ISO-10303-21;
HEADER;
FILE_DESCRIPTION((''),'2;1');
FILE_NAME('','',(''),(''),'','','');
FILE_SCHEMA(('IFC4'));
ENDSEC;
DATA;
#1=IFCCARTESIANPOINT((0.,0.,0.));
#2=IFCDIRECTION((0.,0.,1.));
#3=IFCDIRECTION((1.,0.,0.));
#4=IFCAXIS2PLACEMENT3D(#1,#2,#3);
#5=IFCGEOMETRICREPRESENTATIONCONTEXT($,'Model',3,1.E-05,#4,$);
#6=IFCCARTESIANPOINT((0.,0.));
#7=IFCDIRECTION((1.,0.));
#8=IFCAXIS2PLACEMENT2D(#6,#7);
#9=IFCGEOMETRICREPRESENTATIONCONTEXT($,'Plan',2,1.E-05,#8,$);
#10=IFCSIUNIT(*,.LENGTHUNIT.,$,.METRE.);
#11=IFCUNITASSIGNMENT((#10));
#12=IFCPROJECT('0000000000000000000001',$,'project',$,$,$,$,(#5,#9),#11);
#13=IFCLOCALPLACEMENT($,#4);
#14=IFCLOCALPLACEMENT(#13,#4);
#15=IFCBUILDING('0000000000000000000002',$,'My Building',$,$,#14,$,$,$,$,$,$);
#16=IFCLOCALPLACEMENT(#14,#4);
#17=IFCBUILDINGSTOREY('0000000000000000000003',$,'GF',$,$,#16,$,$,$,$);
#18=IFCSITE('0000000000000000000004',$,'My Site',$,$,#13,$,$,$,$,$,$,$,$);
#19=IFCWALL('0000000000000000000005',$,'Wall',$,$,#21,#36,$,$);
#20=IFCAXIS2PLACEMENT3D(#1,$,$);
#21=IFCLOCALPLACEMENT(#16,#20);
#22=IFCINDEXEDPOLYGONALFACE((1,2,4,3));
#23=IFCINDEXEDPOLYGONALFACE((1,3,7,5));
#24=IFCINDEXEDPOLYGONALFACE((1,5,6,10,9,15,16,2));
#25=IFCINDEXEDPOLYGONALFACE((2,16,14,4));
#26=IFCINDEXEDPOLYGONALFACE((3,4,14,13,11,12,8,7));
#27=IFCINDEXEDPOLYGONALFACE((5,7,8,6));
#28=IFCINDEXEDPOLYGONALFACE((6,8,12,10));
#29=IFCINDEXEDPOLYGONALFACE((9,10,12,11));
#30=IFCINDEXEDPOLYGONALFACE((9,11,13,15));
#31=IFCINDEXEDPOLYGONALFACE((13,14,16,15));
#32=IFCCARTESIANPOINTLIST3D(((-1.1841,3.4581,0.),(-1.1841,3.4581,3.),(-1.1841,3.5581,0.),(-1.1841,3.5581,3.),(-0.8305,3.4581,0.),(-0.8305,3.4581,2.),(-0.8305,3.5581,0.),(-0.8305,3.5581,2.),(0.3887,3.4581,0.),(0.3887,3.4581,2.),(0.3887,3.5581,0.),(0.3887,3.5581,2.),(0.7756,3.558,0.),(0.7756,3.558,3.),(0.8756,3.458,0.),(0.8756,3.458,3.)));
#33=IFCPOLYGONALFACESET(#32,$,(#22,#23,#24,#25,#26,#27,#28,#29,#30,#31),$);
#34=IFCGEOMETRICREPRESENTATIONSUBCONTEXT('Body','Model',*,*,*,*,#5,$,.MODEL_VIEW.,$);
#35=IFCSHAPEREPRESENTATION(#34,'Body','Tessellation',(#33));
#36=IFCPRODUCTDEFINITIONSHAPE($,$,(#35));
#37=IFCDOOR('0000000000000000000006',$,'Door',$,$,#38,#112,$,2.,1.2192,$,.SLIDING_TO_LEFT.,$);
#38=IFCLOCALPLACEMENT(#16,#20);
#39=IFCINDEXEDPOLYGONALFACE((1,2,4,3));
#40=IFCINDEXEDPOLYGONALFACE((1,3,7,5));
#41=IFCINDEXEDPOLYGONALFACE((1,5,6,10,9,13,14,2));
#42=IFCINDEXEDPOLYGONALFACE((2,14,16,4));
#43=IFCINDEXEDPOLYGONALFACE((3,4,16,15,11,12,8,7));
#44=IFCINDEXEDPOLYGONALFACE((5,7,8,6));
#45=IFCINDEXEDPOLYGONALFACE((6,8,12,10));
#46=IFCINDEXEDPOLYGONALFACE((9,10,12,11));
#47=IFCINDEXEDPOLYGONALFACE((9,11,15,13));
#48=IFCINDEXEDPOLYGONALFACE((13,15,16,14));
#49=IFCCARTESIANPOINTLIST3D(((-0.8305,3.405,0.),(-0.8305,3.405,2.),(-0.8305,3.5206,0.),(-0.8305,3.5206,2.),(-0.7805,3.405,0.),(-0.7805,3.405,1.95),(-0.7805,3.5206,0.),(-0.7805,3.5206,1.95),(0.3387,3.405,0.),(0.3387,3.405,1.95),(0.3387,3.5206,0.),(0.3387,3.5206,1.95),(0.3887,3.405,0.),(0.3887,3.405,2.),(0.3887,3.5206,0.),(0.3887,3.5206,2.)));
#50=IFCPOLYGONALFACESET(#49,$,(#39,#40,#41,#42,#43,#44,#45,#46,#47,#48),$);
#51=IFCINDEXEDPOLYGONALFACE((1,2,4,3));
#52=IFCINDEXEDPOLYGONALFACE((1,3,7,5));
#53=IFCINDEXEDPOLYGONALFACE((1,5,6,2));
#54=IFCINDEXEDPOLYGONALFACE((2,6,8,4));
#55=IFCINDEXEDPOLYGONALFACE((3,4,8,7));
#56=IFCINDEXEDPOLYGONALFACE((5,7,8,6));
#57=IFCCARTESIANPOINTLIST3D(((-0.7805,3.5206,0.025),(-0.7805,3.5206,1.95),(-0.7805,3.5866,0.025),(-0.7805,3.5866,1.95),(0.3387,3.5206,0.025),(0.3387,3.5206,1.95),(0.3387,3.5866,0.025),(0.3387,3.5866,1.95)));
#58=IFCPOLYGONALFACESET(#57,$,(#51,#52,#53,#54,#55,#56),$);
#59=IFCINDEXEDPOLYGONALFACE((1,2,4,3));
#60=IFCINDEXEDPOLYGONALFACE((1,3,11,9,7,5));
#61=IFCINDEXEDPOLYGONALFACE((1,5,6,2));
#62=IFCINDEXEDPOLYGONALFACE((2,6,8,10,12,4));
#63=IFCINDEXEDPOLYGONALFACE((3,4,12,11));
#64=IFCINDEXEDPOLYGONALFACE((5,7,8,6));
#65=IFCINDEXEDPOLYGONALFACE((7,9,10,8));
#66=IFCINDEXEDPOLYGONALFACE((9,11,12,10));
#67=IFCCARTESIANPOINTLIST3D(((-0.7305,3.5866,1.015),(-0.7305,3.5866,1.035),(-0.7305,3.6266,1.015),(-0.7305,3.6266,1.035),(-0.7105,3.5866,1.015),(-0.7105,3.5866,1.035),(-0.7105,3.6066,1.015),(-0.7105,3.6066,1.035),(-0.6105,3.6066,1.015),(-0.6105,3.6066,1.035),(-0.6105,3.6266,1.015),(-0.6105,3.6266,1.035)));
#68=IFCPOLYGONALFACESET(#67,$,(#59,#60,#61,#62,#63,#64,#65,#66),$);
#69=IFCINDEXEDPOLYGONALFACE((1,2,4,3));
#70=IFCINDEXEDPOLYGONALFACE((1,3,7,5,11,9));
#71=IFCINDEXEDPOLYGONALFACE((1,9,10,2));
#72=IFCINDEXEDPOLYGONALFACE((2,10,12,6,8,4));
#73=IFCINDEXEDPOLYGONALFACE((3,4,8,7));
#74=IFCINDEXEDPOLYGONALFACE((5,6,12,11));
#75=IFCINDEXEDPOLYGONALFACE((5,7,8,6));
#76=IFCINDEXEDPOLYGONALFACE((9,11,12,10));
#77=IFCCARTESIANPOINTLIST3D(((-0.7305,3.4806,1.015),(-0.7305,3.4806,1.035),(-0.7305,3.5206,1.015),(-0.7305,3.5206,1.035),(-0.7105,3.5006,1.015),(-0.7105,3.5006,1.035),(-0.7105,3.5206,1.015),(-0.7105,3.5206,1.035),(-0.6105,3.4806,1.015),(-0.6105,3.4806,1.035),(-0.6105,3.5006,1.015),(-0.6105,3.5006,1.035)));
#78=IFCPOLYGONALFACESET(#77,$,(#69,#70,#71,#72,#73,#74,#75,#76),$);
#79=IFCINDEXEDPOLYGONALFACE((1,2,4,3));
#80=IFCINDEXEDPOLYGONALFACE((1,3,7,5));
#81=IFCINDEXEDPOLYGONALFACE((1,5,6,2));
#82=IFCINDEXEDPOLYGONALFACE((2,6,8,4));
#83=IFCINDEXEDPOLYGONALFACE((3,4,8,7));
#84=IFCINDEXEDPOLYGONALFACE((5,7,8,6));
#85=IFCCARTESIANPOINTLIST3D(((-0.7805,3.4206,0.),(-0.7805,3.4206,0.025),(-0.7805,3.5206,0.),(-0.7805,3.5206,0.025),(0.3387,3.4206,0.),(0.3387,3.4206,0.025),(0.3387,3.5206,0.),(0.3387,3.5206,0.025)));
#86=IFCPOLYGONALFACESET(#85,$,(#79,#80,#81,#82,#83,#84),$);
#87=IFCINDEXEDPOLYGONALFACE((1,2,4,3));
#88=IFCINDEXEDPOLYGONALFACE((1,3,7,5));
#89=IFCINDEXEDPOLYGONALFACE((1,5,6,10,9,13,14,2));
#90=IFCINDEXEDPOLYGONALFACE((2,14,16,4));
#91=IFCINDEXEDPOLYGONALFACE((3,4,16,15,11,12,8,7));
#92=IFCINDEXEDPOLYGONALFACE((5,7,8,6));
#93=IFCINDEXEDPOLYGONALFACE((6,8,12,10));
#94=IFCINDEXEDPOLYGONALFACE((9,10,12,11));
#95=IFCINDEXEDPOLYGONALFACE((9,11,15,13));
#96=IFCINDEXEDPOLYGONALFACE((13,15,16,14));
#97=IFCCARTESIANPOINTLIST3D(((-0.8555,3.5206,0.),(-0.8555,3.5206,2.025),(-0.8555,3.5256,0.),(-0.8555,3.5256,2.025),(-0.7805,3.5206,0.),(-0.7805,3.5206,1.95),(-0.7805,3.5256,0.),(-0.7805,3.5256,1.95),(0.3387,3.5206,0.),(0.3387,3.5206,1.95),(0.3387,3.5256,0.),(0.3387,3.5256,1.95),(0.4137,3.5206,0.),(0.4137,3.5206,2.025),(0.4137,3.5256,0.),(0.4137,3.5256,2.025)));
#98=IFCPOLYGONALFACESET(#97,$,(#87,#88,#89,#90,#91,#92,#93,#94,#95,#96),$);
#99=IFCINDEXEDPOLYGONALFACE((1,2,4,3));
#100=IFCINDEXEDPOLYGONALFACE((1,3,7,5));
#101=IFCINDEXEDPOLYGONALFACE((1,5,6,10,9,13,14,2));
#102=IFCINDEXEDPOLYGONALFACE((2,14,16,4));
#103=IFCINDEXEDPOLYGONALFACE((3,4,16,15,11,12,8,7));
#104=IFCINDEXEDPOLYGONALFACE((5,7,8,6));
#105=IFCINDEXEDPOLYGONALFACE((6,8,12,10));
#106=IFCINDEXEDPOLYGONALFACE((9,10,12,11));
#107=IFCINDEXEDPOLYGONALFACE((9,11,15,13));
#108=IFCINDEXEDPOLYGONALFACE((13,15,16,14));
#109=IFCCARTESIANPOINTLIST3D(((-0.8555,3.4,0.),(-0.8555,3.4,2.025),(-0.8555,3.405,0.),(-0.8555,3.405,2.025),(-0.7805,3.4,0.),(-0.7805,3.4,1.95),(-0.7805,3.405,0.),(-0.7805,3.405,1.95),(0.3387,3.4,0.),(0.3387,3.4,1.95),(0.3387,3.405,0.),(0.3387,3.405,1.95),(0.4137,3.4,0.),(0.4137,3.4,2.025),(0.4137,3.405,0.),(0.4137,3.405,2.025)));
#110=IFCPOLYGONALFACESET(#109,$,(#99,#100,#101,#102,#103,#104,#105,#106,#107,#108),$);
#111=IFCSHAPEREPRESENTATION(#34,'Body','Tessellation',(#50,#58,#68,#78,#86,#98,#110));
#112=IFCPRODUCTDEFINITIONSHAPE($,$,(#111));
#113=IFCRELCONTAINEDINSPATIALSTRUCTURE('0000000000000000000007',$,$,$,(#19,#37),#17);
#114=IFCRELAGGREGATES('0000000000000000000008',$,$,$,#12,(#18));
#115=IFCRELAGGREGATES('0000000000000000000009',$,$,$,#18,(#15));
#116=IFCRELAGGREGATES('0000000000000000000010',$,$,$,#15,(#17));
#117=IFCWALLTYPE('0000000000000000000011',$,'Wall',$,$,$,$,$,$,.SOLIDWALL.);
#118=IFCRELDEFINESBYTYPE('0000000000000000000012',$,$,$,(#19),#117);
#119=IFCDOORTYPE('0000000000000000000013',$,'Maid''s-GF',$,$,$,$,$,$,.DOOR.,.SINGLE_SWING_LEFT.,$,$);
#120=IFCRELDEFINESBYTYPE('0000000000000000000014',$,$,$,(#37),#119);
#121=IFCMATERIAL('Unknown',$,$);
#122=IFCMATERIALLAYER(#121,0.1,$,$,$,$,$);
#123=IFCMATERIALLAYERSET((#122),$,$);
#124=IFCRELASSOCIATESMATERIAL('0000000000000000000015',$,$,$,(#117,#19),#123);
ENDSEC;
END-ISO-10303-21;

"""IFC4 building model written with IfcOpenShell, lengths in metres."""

from ifc_helpers import new_model, entity, si_unit, frame, origin_with_axes, origin_2d_with_axis, place, context, subcontext, project, spatial, line, indexed_curve, outline, extrude, shape, source, transform, mapped, material, layer, layer_set, layer_usage, type_object, type_shapes, element, fill, save


model = new_model("IFC4")

# Units and contexts
model_context = context("Model", 3, precision=1e-05, world=origin_with_axes())
plan_context = context("Plan", 2, precision=1e-05, world=origin_2d_with_axis())
body_context_1 = subcontext(model_context, "Body", "Model", "MODEL_VIEW")
body_context_2 = subcontext(plan_context, "Body", "Plan", "PLAN_VIEW")
ifc_project = project(units=[si_unit("LENGTHUNIT", "METRE")], contexts=[model_context, plan_context])

# Site, building, storey
site_placement = place(None, origin_with_axes())
site = spatial("IfcSite", under=ifc_project, at=site_placement, Name="My Site")
building_placement = place(site_placement, origin_with_axes())
building = spatial("IfcBuilding", under=site, at=building_placement, Name="My Building")
storey_placement = place(building_placement, origin_with_axes())
storey = spatial("IfcBuildingStorey", under=building, at=storey_placement, Name="GF")

# Shared definitions
ifc_material_1 = material(Name="Unknown")

# Shared definitions
ifc_layer_1 = layer(ifc_material_1, 0.1)
ifc_layer_set_1 = layer_set([ifc_layer_1])
wall_type = type_object("IfcWallType", Name="Wall", PredefinedType="SOLIDWALL", material=ifc_layer_set_1)

# Wall, opening, door
ifc_layer_usage_1 = layer_usage(ifc_layer_set_1, "AXIS2", "POSITIVE", 0.0)
wall_1_placement = place(storey_placement, frame((0.7756, 3.558, 0.0), z_axis=(0.0, 0.0, 1.0), x_axis=(-1.0, 0.0, 0.0)))
wall_1 = element("IfcWall", 1, at=wall_1_placement, inside=storey, type_object=wall_type, material=ifc_layer_usage_1, Name="Wall", context=body_context_1, shape_type="SweptSolid", body=[
    extrude(outline(indexed_curve([(0.0, 0.0), (-0.1, 0.1), (1.9596, 0.1), (1.9596, 0.0)], segments=[line(1, 2, 3, 4, 1)])), origin_with_axes(), (0.0, 0.0, 1.0), 3.0),
])
shared_shape_1 = source(origin_with_axes(), body_context_1, "Body", "SweptSolid", [
    extrude(outline(indexed_curve([(0.0, 0.0), (1.2192, 0.0), (1.2192, 2.0), (0.0, 2.0)], segments=[line(1, 2, 3, 4, 1)])), frame((0.0, -0.6, 0.0), z_axis=(0.0, -1.0, 0.0), x_axis=(1.0, 0.0, 0.0)), (0.0, 0.0, -1.0), 1.2),
])
opening_1_placement = place(wall_1_placement, frame((0.3869, 0.0375, 0.0), z_axis=(0.0, 0.0, 1.0), x_axis=(1.0, -0.000003, 0.0)))
opening_1 = element("IfcOpeningElement", 2, at=opening_1_placement, cuts=wall_1, PredefinedType="OPENING", context=body_context_1, shape_type="MappedRepresentation", body=[
    mapped(shared_shape_1, transform((0.0, 0.0, 0.0), x_axis=(1.0, 0.0, 0.0), y_axis=(0.0, 1.0, 0.0), z_axis=(0.0, 0.0, 1.0), scale=1.0)),
])
door_type_1 = type_object("IfcDoorType", Name="Maid's-GF", OperationType="SINGLE_SWING_LEFT", PredefinedType="DOOR")
shared_shape_2 = source(origin_with_axes(), body_context_1, "Body", "SweptSolid", [
    extrude(outline(indexed_curve([(0.0, 0.0), (0.0, 2.0), (1.2192, 2.0), (1.2192, 0.0), (1.1692, 0.0), (1.1692, 1.95), (0.05, 1.95), (0.05, 0.0)], segments=[line(1, 2, 3, 4, 5, 6, 7, 8, 1)])), frame((0.0, 0.0, 0.0), z_axis=(0.0, -1.0, 0.0), x_axis=(1.0, 0.0, 0.0)), (0.0, 0.0, -1.0), 0.1156),
    extrude(outline(indexed_curve([(0.0, 0.0), (1.1192, 0.0), (1.1192, 0.0661), (0.0, 0.0661)], segments=[line(1, 2, 3, 4, 1)])), frame((0.05, -0.0661, 0.025), z_axis=(0.0, 0.0, 1.0), x_axis=(1.0, 0.0, 0.0)), (0.0, 0.0, 1.0), 1.925),
    extrude(outline(indexed_curve([(0.0, 0.0), (0.0, -0.04), (-0.12, -0.04), (-0.12, -0.02), (-0.02, -0.02), (-0.02, 0.0)], segments=[line(1, 2, 3, 4, 5, 6, 1)])), frame((1.1192, -0.0661, 1.015), z_axis=(0.0, 0.0, 1.0), x_axis=(1.0, 0.0, 0.0)), (0.0, 0.0, 1.0), 0.02),
    extrude(outline(indexed_curve([(0.0, 0.0), (0.0, 0.04), (-0.12, 0.04), (-0.12, 0.02), (-0.02, 0.02), (-0.02, 0.0)], segments=[line(1, 2, 3, 4, 5, 6, 1)])), frame((1.1192, 0.0, 1.015), z_axis=(0.0, 0.0, 1.0), x_axis=(1.0, 0.0, 0.0)), (0.0, 0.0, 1.0), 0.02),
    extrude(outline(indexed_curve([(0.0, 0.0), (1.1192, 0.0), (1.1192, 0.1), (0.0, 0.1)], segments=[line(1, 2, 3, 4, 1)])), frame((0.05, 0.0, 0.0), z_axis=(0.0, 0.0, 1.0), x_axis=(1.0, 0.0, 0.0)), (0.0, 0.0, 1.0), 0.025),
    extrude(outline(indexed_curve([(0.0, 0.0), (0.0, 2.025), (1.2692, 2.025), (1.2692, 0.0), (1.1942, 0.0), (1.1942, 1.95), (0.075, 1.95), (0.075, 0.0)], segments=[line(1, 2, 3, 4, 5, 6, 7, 8, 1)])), frame((-0.025, -0.005, 0.0), z_axis=(0.0, -1.0, 0.0), x_axis=(1.0, 0.0, 0.0)), (0.0, 0.0, -1.0), 0.005),
    extrude(outline(indexed_curve([(0.0, 0.0), (0.0, 2.025), (1.2692, 2.025), (1.2692, 0.0), (1.1942, 0.0), (1.1942, 1.95), (0.075, 1.95), (0.075, 0.0)], segments=[line(1, 2, 3, 4, 5, 6, 7, 8, 1)])), frame((-0.025, 0.1156, 0.0), z_axis=(0.0, -1.0, 0.0), x_axis=(1.0, 0.0, 0.0)), (0.0, 0.0, -1.0), 0.005),
])
shared_shape_3 = source(origin_with_axes(), body_context_2, "Body", "Curve2D", [
    entity("IfcIndexedPolyCurve", entity("IfcCartesianPointList2D", [[0.0, 0.0], [0.05, 0.0], [0.05, 0.1156], [0.0, 0.1156]]), [entity("IfcLineIndex", [1, 2, 3, 4, 1])]),
    entity("IfcIndexedPolyCurve", entity("IfcCartesianPointList2D", [[1.2192, 0.0], [1.1692, 0.0], [1.1692, 0.1156], [1.2192, 0.1156]]), [entity("IfcLineIndex", [1, 2, 3, 4, 1])]),
    entity("IfcIndexedPolyCurve", entity("IfcCartesianPointList2D", [[-0.5096, -0.0661], [0.6096, -0.0661], [0.6096, 0.0], [-0.5096, 0.0]]), [entity("IfcLineIndex", [1, 2, 3, 4, 1])]),
])
type_shapes(door_type_1, [shared_shape_2, shared_shape_3])
door_1_placement = place(opening_1_placement, frame((0.0, 0.0, 0.0), z_axis=(0.0, 0.0, 1.0), x_axis=(1.0, 0.0, 0.0)))
door_1 = element("IfcDoor", 3, at=door_1_placement, inside=storey, type_object=door_type_1, Name="Door", OperationType="SLIDING_TO_LEFT", OverallHeight=2.0, OverallWidth=1.2192, shapes=[
    shape(body_context_1, "Body", "MappedRepresentation", [mapped(shared_shape_2, transform((0.0, 0.0, 0.0), x_axis=(1.0, 0.0, 0.0), y_axis=(0.0, 1.0, 0.0), z_axis=(0.0, 0.0, 1.0), scale=1.0))]),
    shape(body_context_2, "Body", "MappedRepresentation", [mapped(shared_shape_3, transform((0.0, 0.0, 0.0), x_axis=(1.0, 0.0, 0.0), y_axis=(0.0, 1.0, 0.0), z_axis=(0.0, 0.0, 1.0), scale=1.0))]),
])
fill(opening_1, door_1)

save(model, "model.ifc")
